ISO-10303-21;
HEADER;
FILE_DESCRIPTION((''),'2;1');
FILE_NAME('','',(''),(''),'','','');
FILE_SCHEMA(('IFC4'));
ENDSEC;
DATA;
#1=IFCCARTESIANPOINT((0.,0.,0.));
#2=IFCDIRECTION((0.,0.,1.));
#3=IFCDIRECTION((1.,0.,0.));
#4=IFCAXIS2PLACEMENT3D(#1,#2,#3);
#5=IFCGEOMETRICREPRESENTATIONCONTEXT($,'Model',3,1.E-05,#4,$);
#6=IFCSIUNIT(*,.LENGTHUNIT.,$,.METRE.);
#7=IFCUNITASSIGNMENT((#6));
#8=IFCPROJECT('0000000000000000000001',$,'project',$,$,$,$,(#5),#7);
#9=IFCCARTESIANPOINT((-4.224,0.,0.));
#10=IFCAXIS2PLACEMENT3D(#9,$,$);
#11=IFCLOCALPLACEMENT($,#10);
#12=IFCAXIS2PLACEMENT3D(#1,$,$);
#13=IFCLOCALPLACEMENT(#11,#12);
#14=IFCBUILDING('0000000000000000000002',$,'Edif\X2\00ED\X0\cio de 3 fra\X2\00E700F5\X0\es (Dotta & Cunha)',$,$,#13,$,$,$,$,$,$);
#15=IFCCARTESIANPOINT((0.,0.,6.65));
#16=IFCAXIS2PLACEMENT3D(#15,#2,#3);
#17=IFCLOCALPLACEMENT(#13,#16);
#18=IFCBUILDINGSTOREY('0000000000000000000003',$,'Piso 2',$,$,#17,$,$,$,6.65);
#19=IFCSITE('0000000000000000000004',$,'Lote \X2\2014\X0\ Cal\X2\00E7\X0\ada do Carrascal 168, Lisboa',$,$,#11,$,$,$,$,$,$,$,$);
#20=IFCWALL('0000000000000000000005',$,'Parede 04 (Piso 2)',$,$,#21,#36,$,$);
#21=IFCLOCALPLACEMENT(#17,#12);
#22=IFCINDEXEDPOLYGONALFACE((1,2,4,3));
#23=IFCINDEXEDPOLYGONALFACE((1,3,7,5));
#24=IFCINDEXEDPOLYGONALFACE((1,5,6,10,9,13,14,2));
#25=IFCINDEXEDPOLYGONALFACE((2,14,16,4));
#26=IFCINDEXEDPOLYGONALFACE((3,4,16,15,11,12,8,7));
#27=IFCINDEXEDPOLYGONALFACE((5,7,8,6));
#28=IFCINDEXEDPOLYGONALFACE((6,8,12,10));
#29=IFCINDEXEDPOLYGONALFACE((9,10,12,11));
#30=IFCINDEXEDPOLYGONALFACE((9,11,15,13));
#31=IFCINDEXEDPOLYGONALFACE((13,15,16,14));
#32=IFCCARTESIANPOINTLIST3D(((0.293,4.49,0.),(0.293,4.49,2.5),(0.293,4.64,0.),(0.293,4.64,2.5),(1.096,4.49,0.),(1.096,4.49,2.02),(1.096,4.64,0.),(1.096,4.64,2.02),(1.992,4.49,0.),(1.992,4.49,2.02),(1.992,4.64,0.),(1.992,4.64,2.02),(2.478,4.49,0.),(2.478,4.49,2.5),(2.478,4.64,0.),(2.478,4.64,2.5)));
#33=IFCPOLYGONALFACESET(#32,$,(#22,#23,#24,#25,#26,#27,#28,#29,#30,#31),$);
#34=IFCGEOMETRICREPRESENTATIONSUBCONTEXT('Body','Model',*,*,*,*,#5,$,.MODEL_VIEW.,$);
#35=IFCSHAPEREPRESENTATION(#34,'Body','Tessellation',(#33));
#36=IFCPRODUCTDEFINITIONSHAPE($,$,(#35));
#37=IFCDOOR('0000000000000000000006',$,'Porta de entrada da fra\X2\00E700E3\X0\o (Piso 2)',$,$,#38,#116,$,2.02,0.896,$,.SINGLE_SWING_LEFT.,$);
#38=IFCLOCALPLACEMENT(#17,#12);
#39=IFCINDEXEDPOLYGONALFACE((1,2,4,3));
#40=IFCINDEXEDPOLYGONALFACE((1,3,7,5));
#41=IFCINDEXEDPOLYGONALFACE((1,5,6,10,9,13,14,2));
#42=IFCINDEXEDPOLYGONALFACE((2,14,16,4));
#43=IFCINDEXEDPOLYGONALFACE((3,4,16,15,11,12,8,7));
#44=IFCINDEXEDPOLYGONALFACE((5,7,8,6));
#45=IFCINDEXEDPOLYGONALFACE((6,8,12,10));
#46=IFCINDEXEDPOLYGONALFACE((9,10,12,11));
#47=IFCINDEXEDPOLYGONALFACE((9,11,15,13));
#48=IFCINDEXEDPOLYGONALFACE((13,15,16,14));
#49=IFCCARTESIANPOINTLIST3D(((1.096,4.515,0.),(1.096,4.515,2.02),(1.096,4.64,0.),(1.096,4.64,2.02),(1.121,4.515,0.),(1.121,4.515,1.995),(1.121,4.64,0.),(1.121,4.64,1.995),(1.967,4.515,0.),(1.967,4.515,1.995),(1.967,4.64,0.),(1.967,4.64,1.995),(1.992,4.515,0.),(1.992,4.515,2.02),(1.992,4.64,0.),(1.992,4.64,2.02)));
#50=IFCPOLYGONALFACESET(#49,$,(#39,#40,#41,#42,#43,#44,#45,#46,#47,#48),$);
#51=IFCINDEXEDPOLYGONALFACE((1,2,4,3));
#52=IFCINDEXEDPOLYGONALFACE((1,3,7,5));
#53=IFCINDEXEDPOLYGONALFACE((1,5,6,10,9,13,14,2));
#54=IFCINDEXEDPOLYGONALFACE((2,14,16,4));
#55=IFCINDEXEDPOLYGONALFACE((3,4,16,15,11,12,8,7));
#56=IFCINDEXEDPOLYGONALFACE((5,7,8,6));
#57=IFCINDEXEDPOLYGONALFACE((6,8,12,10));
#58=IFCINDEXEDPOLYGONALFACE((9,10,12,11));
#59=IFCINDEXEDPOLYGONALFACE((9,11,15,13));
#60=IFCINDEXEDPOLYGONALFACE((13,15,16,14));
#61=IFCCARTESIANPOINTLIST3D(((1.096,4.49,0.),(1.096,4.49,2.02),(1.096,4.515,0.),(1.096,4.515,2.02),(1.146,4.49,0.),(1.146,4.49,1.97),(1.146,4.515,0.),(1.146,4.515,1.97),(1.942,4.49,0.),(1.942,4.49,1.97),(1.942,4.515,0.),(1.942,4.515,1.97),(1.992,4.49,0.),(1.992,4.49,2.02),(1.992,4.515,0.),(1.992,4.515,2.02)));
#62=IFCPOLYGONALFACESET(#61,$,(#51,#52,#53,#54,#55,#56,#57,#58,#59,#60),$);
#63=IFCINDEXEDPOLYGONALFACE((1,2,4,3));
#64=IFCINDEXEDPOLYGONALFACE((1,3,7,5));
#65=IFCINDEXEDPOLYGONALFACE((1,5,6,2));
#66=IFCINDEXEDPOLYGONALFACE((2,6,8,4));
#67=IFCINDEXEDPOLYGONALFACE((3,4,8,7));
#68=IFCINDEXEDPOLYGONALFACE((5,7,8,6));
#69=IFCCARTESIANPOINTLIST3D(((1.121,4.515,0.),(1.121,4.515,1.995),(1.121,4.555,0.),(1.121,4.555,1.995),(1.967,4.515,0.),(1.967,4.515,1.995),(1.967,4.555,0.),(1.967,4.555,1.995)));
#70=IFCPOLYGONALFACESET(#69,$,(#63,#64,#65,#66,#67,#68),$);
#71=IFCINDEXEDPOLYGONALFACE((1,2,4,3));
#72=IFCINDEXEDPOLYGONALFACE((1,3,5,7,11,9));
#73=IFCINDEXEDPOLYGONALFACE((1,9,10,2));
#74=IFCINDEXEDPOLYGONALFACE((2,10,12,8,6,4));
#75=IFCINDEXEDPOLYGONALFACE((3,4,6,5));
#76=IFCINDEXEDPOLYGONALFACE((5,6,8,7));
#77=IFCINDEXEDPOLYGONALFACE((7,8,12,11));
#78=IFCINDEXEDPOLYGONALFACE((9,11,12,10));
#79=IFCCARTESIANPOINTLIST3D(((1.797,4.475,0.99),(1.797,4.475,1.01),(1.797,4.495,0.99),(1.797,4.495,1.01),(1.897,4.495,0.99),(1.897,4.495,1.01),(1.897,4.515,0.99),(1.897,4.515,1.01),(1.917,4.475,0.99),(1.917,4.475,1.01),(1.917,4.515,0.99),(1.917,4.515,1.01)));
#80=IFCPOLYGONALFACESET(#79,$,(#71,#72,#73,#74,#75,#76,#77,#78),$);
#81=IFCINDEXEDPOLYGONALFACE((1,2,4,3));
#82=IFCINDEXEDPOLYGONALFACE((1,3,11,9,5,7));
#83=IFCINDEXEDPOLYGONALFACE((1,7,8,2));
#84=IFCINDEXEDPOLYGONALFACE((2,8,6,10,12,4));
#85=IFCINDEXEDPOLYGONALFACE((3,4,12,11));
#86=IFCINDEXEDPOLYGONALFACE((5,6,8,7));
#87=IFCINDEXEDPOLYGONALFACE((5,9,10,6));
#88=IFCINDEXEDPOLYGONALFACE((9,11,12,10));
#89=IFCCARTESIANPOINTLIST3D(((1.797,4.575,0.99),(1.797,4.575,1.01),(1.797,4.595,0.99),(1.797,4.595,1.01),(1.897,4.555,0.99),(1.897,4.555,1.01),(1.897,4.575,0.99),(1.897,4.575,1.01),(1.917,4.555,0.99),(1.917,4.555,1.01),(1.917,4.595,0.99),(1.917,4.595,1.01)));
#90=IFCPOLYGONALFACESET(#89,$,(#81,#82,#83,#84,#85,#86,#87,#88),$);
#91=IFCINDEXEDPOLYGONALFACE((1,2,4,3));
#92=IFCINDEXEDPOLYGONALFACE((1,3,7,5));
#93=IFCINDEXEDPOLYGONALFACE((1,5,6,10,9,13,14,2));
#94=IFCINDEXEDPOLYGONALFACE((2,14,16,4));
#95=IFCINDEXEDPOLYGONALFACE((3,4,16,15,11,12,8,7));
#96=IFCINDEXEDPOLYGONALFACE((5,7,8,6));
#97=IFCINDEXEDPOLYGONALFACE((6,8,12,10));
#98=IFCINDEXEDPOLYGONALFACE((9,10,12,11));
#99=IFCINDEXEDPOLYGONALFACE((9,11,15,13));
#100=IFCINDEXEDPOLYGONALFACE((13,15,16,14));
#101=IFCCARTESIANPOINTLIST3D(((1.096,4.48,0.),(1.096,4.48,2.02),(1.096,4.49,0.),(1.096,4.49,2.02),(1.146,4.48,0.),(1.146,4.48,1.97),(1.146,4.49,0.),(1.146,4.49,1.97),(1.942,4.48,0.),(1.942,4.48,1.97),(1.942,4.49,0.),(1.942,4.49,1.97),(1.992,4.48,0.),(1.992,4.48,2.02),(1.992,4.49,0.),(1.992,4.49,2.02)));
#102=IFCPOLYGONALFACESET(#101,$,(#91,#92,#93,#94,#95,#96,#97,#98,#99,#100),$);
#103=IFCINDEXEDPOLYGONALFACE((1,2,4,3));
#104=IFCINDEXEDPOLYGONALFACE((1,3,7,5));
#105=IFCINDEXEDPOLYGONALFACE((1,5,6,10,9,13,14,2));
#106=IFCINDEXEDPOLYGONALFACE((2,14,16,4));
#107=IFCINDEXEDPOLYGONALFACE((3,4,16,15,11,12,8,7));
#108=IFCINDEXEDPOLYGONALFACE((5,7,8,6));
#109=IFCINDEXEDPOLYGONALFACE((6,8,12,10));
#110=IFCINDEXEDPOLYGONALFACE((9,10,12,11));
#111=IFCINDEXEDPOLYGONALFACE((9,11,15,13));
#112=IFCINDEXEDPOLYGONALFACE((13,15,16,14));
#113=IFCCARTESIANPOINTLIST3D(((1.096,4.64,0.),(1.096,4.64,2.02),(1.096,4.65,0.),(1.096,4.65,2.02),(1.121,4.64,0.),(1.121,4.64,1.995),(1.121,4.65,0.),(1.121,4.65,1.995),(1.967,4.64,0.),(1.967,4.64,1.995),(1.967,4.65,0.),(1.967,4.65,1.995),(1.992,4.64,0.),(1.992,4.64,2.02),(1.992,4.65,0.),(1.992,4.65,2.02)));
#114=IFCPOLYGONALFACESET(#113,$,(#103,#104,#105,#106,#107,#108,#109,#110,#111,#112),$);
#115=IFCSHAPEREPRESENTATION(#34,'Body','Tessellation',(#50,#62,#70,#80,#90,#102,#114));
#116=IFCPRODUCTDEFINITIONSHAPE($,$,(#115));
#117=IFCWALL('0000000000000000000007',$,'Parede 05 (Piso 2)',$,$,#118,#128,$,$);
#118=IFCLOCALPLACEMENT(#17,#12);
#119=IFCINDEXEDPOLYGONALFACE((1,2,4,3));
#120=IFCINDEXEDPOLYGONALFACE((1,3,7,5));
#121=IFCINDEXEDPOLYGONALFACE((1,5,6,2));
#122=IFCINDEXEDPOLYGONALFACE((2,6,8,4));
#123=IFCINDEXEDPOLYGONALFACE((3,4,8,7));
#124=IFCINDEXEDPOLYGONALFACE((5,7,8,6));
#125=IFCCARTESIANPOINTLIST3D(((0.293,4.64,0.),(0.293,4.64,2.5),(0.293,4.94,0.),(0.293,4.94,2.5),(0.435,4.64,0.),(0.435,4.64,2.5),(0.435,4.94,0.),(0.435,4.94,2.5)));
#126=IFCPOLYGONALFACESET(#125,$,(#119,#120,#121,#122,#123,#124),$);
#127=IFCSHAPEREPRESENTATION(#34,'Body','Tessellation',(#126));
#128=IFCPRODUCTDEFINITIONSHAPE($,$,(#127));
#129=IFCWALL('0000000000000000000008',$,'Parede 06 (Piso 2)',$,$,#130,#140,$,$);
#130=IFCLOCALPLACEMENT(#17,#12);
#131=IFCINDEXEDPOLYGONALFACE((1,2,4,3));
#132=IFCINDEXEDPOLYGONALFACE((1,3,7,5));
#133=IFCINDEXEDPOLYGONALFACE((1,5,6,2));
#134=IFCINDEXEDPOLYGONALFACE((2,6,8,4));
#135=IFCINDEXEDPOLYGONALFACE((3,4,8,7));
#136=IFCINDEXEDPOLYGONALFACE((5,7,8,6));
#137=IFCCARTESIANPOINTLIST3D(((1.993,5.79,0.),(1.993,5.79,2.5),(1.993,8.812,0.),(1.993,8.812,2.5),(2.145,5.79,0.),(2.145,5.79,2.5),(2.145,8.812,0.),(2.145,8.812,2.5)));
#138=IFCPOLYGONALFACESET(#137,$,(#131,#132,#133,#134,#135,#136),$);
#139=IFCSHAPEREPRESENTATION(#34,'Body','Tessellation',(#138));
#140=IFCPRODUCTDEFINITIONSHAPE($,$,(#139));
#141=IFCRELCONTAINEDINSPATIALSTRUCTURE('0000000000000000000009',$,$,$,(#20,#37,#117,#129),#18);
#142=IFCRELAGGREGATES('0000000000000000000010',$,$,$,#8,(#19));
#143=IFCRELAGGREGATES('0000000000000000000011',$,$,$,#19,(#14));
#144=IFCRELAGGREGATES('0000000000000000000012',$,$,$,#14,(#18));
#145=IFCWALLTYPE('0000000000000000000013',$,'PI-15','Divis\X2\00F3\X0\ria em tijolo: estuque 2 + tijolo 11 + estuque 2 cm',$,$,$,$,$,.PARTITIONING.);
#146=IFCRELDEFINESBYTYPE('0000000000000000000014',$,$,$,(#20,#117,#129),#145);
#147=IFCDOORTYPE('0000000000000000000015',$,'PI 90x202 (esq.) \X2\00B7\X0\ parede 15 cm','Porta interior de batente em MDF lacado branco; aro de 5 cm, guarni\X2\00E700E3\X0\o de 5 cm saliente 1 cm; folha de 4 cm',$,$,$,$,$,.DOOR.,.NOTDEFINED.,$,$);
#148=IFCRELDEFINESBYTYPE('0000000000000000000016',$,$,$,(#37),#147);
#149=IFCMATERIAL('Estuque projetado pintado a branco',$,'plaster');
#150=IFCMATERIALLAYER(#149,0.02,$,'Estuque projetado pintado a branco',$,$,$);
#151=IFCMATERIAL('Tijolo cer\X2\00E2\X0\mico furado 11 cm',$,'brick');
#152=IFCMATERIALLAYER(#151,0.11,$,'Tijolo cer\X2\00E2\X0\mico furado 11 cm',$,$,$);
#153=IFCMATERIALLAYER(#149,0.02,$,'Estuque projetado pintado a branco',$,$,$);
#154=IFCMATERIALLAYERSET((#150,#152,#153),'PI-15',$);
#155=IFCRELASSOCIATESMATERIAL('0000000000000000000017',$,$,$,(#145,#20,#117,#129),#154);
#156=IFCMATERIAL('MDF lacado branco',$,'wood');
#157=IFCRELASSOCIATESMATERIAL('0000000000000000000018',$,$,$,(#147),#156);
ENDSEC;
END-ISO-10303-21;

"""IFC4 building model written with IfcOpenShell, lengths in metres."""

from ifc_helpers import new_model, si_unit, frame, origin, origin_with_axes, place, context, subcontext, project, spatial, line, indexed_curve, outline, extrude, source, transform, mapped, material, layer, layer_set, layer_usage, type_object, type_shapes, element, fill, save


model = new_model("IFC4")

# Units and contexts
model_context = context("Model", 3, precision=1e-05, world=origin_with_axes())
body_context = subcontext(model_context, "Body", "Model", "MODEL_VIEW")
ifc_project = project(units=[si_unit("LENGTHUNIT", "METRE")], contexts=[model_context])

# Site, building, storey
site_placement = place(None, frame((-4.224, 0.0, 0.0)))
site = spatial("IfcSite", under=ifc_project, at=site_placement, Name="Lote — Calçada do Carrascal 168, Lisboa")
building_placement = place(site_placement, origin())
building = spatial("IfcBuilding", under=site, at=building_placement, Name="Edifício de 3 frações (Dotta & Cunha)")
storey_placement = place(building_placement, frame((0.0, 0.0, 6.65), z_axis=(0.0, 0.0, 1.0), x_axis=(1.0, 0.0, 0.0)))
storey = spatial("IfcBuildingStorey", under=building, at=storey_placement, Name="Piso 2", Elevation=6.65)

# Shared definitions
ifc_material_1 = material(Name="Estuque projetado pintado a branco", Category="plaster")
ifc_layer_1 = layer(ifc_material_1, 0.02, Name="Estuque projetado pintado a branco")
ifc_material_2 = material(Name="Tijolo cerâmico furado 11 cm", Category="brick")
ifc_layer_2 = layer(ifc_material_2, 0.11, Name="Tijolo cerâmico furado 11 cm")
ifc_layer_3 = layer(ifc_material_1, 0.02, Name="Estuque projetado pintado a branco")
ifc_layer_set_1 = layer_set([ifc_layer_1, ifc_layer_2, ifc_layer_3], Name="PI-15")
wall_type_1 = type_object("IfcWallType", Name="PI-15", Description="Divisória em tijolo: estuque 2 + tijolo 11 + estuque 2 cm", PredefinedType="PARTITIONING", material=ifc_layer_set_1)

# Wall, opening, door
ifc_layer_usage_1 = layer_usage(ifc_layer_set_1, "AXIS2", "POSITIVE", 0.0)
wall_1_placement = place(storey_placement, origin_with_axes())
wall_1 = element("IfcWall", 1, at=wall_1_placement, inside=storey, type_object=wall_type_1, material=ifc_layer_usage_1, Name="Parede 04 (Piso 2)", context=body_context, shape_type="SweptSolid", body=[
    extrude(outline(indexed_curve([(2.478, 4.49), (2.478, 4.64), (0.293, 4.64), (0.293, 4.49)], segments=[line(1, 2, 3, 4, 1)])), origin_with_axes(), (0.0, 0.0, 1.0), 2.5),
])
opening_1_placement = place(wall_1_placement, origin_with_axes())
opening_1 = element("IfcOpeningElement", 2, at=opening_1_placement, cuts=wall_1, context=body_context, shape_type="SweptSolid", body=[
    extrude(outline(indexed_curve([(1.992, 4.488), (1.992, 4.642), (1.096, 4.642), (1.096, 4.488)], segments=[line(1, 2, 3, 4, 1)])), origin_with_axes(), (0.0, 0.0, 1.0), 2.02),
])
ifc_material_3 = material(Name="MDF lacado branco", Category="wood")
door_type_1 = type_object("IfcDoorType", Name="PI 90x202 (esq.) · parede 15 cm", Description="Porta interior de batente em MDF lacado branco; aro de 5 cm, guarnição de 5 cm saliente 1 cm; folha de 4 cm", OperationType="NOTDEFINED", PredefinedType="DOOR", material=ifc_material_3)
shared_shape_1 = source(origin_with_axes(), body_context, "Body", "SweptSolid", [
    extrude(outline(indexed_curve([(0.0, 0.0), (0.0, 2.02), (0.896, 2.02), (0.896, 0.0), (0.871, 0.0), (0.871, 1.995), (0.025, 1.995), (0.025, 0.0)], segments=[line(1, 2, 3, 4, 5, 6, 7, 8, 1)])), frame((0.0, 0.025, 0.0), z_axis=(0.0, -1.0, 0.0), x_axis=(1.0, 0.0, 0.0)), (0.0, 0.0, -1.0), 0.125),
    extrude(outline(indexed_curve([(0.0, 0.0), (0.0, 2.02), (0.896, 2.02), (0.896, 0.0), (0.846, 0.0), (0.846, 1.97), (0.05, 1.97), (0.05, 0.0)], segments=[line(1, 2, 3, 4, 5, 6, 7, 8, 1)])), frame((0.0, 0.0, 0.0), z_axis=(0.0, -1.0, 0.0), x_axis=(1.0, 0.0, 0.0)), (0.0, 0.0, -1.0), 0.025),
    extrude(outline(indexed_curve([(0.0, 0.0), (0.846, 0.0), (0.846, 0.04), (0.0, 0.04)], segments=[line(1, 2, 3, 4, 1)])), frame((0.025, 0.025, 0.0), z_axis=(0.0, 0.0, 1.0), x_axis=(1.0, 0.0, 0.0)), (0.0, 0.0, 1.0), 1.995),
    extrude(outline(indexed_curve([(0.0, 0.0), (0.0, -0.04), (-0.12, -0.04), (-0.12, -0.02), (-0.02, -0.02), (-0.02, 0.0)], segments=[line(1, 2, 3, 4, 5, 6, 1)])), frame((0.821, 0.025, 0.99), z_axis=(0.0, 0.0, 1.0), x_axis=(1.0, 0.0, 0.0)), (0.0, 0.0, 1.0), 0.02),
    extrude(outline(indexed_curve([(0.0, 0.0), (0.0, 0.04), (-0.12, 0.04), (-0.12, 0.02), (-0.02, 0.02), (-0.02, 0.0)], segments=[line(1, 2, 3, 4, 5, 6, 1)])), frame((0.821, 0.065, 0.99), z_axis=(0.0, 0.0, 1.0), x_axis=(1.0, 0.0, 0.0)), (0.0, 0.0, 1.0), 0.02),
    extrude(outline(indexed_curve([(0.0, 0.0), (0.0, 2.02), (0.896, 2.02), (0.896, 0.0), (0.846, 0.0), (0.846, 1.97), (0.05, 1.97), (0.05, 0.0)], segments=[line(1, 2, 3, 4, 5, 6, 7, 8, 1)])), frame((0.0, -0.01, 0.0), z_axis=(0.0, -1.0, 0.0), x_axis=(1.0, 0.0, 0.0)), (0.0, 0.0, -1.0), 0.01),
    extrude(outline(indexed_curve([(0.0, 0.0), (0.0, 2.02), (0.896, 2.02), (0.896, 0.0), (0.871, 0.0), (0.871, 1.995), (0.025, 1.995), (0.025, 0.0)], segments=[line(1, 2, 3, 4, 5, 6, 7, 8, 1)])), frame((0.0, 0.15, 0.0), z_axis=(0.0, -1.0, 0.0), x_axis=(1.0, 0.0, 0.0)), (0.0, 0.0, -1.0), 0.01),
])
type_shapes(door_type_1, [shared_shape_1])
door_1_placement = place(storey_placement, frame((1.096, 4.49, 0.0), z_axis=(0.0, 0.0, 1.0), x_axis=(1.0, 0.0, 0.0)))
door_1 = element("IfcDoor", 3, at=door_1_placement, inside=storey, type_object=door_type_1, Name="Porta de entrada da fração (Piso 2)", OperationType="SINGLE_SWING_LEFT", OverallHeight=2.02, OverallWidth=0.896, context=body_context, shape_type="MappedRepresentation", body=[
    mapped(shared_shape_1, transform((0.0, 0.0, 0.0), x_axis=(1.0, 0.0, 0.0), y_axis=(0.0, 1.0, 0.0), z_axis=(0.0, 0.0, 1.0), scale=1.0)),
])
fill(opening_1, door_1)

# Walls
ifc_layer_usage_2 = layer_usage(ifc_layer_set_1, "AXIS2", "POSITIVE", 0.0)
wall_2_placement = place(storey_placement, origin_with_axes())
element("IfcWall", 4, at=wall_2_placement, inside=storey, type_object=wall_type_1, material=ifc_layer_usage_2, Name="Parede 05 (Piso 2)", context=body_context, shape_type="SweptSolid", body=[
    extrude(outline(indexed_curve([(0.435, 4.64), (0.435, 4.94), (0.293, 4.94), (0.293, 4.64)], segments=[line(1, 2, 3, 4, 1)])), origin_with_axes(), (0.0, 0.0, 1.0), 2.5),
])
ifc_layer_usage_3 = layer_usage(ifc_layer_set_1, "AXIS2", "POSITIVE", 0.0)
wall_3_placement = place(storey_placement, origin_with_axes())
element("IfcWall", 5, at=wall_3_placement, inside=storey, type_object=wall_type_1, material=ifc_layer_usage_3, Name="Parede 06 (Piso 2)", context=body_context, shape_type="SweptSolid", body=[
    extrude(outline(indexed_curve([(2.145, 5.79), (2.145, 8.812), (1.993, 8.812), (1.993, 5.79)], segments=[line(1, 2, 3, 4, 1)])), origin_with_axes(), (0.0, 0.0, 1.0), 2.5),
])

save(model, "model.ifc")
